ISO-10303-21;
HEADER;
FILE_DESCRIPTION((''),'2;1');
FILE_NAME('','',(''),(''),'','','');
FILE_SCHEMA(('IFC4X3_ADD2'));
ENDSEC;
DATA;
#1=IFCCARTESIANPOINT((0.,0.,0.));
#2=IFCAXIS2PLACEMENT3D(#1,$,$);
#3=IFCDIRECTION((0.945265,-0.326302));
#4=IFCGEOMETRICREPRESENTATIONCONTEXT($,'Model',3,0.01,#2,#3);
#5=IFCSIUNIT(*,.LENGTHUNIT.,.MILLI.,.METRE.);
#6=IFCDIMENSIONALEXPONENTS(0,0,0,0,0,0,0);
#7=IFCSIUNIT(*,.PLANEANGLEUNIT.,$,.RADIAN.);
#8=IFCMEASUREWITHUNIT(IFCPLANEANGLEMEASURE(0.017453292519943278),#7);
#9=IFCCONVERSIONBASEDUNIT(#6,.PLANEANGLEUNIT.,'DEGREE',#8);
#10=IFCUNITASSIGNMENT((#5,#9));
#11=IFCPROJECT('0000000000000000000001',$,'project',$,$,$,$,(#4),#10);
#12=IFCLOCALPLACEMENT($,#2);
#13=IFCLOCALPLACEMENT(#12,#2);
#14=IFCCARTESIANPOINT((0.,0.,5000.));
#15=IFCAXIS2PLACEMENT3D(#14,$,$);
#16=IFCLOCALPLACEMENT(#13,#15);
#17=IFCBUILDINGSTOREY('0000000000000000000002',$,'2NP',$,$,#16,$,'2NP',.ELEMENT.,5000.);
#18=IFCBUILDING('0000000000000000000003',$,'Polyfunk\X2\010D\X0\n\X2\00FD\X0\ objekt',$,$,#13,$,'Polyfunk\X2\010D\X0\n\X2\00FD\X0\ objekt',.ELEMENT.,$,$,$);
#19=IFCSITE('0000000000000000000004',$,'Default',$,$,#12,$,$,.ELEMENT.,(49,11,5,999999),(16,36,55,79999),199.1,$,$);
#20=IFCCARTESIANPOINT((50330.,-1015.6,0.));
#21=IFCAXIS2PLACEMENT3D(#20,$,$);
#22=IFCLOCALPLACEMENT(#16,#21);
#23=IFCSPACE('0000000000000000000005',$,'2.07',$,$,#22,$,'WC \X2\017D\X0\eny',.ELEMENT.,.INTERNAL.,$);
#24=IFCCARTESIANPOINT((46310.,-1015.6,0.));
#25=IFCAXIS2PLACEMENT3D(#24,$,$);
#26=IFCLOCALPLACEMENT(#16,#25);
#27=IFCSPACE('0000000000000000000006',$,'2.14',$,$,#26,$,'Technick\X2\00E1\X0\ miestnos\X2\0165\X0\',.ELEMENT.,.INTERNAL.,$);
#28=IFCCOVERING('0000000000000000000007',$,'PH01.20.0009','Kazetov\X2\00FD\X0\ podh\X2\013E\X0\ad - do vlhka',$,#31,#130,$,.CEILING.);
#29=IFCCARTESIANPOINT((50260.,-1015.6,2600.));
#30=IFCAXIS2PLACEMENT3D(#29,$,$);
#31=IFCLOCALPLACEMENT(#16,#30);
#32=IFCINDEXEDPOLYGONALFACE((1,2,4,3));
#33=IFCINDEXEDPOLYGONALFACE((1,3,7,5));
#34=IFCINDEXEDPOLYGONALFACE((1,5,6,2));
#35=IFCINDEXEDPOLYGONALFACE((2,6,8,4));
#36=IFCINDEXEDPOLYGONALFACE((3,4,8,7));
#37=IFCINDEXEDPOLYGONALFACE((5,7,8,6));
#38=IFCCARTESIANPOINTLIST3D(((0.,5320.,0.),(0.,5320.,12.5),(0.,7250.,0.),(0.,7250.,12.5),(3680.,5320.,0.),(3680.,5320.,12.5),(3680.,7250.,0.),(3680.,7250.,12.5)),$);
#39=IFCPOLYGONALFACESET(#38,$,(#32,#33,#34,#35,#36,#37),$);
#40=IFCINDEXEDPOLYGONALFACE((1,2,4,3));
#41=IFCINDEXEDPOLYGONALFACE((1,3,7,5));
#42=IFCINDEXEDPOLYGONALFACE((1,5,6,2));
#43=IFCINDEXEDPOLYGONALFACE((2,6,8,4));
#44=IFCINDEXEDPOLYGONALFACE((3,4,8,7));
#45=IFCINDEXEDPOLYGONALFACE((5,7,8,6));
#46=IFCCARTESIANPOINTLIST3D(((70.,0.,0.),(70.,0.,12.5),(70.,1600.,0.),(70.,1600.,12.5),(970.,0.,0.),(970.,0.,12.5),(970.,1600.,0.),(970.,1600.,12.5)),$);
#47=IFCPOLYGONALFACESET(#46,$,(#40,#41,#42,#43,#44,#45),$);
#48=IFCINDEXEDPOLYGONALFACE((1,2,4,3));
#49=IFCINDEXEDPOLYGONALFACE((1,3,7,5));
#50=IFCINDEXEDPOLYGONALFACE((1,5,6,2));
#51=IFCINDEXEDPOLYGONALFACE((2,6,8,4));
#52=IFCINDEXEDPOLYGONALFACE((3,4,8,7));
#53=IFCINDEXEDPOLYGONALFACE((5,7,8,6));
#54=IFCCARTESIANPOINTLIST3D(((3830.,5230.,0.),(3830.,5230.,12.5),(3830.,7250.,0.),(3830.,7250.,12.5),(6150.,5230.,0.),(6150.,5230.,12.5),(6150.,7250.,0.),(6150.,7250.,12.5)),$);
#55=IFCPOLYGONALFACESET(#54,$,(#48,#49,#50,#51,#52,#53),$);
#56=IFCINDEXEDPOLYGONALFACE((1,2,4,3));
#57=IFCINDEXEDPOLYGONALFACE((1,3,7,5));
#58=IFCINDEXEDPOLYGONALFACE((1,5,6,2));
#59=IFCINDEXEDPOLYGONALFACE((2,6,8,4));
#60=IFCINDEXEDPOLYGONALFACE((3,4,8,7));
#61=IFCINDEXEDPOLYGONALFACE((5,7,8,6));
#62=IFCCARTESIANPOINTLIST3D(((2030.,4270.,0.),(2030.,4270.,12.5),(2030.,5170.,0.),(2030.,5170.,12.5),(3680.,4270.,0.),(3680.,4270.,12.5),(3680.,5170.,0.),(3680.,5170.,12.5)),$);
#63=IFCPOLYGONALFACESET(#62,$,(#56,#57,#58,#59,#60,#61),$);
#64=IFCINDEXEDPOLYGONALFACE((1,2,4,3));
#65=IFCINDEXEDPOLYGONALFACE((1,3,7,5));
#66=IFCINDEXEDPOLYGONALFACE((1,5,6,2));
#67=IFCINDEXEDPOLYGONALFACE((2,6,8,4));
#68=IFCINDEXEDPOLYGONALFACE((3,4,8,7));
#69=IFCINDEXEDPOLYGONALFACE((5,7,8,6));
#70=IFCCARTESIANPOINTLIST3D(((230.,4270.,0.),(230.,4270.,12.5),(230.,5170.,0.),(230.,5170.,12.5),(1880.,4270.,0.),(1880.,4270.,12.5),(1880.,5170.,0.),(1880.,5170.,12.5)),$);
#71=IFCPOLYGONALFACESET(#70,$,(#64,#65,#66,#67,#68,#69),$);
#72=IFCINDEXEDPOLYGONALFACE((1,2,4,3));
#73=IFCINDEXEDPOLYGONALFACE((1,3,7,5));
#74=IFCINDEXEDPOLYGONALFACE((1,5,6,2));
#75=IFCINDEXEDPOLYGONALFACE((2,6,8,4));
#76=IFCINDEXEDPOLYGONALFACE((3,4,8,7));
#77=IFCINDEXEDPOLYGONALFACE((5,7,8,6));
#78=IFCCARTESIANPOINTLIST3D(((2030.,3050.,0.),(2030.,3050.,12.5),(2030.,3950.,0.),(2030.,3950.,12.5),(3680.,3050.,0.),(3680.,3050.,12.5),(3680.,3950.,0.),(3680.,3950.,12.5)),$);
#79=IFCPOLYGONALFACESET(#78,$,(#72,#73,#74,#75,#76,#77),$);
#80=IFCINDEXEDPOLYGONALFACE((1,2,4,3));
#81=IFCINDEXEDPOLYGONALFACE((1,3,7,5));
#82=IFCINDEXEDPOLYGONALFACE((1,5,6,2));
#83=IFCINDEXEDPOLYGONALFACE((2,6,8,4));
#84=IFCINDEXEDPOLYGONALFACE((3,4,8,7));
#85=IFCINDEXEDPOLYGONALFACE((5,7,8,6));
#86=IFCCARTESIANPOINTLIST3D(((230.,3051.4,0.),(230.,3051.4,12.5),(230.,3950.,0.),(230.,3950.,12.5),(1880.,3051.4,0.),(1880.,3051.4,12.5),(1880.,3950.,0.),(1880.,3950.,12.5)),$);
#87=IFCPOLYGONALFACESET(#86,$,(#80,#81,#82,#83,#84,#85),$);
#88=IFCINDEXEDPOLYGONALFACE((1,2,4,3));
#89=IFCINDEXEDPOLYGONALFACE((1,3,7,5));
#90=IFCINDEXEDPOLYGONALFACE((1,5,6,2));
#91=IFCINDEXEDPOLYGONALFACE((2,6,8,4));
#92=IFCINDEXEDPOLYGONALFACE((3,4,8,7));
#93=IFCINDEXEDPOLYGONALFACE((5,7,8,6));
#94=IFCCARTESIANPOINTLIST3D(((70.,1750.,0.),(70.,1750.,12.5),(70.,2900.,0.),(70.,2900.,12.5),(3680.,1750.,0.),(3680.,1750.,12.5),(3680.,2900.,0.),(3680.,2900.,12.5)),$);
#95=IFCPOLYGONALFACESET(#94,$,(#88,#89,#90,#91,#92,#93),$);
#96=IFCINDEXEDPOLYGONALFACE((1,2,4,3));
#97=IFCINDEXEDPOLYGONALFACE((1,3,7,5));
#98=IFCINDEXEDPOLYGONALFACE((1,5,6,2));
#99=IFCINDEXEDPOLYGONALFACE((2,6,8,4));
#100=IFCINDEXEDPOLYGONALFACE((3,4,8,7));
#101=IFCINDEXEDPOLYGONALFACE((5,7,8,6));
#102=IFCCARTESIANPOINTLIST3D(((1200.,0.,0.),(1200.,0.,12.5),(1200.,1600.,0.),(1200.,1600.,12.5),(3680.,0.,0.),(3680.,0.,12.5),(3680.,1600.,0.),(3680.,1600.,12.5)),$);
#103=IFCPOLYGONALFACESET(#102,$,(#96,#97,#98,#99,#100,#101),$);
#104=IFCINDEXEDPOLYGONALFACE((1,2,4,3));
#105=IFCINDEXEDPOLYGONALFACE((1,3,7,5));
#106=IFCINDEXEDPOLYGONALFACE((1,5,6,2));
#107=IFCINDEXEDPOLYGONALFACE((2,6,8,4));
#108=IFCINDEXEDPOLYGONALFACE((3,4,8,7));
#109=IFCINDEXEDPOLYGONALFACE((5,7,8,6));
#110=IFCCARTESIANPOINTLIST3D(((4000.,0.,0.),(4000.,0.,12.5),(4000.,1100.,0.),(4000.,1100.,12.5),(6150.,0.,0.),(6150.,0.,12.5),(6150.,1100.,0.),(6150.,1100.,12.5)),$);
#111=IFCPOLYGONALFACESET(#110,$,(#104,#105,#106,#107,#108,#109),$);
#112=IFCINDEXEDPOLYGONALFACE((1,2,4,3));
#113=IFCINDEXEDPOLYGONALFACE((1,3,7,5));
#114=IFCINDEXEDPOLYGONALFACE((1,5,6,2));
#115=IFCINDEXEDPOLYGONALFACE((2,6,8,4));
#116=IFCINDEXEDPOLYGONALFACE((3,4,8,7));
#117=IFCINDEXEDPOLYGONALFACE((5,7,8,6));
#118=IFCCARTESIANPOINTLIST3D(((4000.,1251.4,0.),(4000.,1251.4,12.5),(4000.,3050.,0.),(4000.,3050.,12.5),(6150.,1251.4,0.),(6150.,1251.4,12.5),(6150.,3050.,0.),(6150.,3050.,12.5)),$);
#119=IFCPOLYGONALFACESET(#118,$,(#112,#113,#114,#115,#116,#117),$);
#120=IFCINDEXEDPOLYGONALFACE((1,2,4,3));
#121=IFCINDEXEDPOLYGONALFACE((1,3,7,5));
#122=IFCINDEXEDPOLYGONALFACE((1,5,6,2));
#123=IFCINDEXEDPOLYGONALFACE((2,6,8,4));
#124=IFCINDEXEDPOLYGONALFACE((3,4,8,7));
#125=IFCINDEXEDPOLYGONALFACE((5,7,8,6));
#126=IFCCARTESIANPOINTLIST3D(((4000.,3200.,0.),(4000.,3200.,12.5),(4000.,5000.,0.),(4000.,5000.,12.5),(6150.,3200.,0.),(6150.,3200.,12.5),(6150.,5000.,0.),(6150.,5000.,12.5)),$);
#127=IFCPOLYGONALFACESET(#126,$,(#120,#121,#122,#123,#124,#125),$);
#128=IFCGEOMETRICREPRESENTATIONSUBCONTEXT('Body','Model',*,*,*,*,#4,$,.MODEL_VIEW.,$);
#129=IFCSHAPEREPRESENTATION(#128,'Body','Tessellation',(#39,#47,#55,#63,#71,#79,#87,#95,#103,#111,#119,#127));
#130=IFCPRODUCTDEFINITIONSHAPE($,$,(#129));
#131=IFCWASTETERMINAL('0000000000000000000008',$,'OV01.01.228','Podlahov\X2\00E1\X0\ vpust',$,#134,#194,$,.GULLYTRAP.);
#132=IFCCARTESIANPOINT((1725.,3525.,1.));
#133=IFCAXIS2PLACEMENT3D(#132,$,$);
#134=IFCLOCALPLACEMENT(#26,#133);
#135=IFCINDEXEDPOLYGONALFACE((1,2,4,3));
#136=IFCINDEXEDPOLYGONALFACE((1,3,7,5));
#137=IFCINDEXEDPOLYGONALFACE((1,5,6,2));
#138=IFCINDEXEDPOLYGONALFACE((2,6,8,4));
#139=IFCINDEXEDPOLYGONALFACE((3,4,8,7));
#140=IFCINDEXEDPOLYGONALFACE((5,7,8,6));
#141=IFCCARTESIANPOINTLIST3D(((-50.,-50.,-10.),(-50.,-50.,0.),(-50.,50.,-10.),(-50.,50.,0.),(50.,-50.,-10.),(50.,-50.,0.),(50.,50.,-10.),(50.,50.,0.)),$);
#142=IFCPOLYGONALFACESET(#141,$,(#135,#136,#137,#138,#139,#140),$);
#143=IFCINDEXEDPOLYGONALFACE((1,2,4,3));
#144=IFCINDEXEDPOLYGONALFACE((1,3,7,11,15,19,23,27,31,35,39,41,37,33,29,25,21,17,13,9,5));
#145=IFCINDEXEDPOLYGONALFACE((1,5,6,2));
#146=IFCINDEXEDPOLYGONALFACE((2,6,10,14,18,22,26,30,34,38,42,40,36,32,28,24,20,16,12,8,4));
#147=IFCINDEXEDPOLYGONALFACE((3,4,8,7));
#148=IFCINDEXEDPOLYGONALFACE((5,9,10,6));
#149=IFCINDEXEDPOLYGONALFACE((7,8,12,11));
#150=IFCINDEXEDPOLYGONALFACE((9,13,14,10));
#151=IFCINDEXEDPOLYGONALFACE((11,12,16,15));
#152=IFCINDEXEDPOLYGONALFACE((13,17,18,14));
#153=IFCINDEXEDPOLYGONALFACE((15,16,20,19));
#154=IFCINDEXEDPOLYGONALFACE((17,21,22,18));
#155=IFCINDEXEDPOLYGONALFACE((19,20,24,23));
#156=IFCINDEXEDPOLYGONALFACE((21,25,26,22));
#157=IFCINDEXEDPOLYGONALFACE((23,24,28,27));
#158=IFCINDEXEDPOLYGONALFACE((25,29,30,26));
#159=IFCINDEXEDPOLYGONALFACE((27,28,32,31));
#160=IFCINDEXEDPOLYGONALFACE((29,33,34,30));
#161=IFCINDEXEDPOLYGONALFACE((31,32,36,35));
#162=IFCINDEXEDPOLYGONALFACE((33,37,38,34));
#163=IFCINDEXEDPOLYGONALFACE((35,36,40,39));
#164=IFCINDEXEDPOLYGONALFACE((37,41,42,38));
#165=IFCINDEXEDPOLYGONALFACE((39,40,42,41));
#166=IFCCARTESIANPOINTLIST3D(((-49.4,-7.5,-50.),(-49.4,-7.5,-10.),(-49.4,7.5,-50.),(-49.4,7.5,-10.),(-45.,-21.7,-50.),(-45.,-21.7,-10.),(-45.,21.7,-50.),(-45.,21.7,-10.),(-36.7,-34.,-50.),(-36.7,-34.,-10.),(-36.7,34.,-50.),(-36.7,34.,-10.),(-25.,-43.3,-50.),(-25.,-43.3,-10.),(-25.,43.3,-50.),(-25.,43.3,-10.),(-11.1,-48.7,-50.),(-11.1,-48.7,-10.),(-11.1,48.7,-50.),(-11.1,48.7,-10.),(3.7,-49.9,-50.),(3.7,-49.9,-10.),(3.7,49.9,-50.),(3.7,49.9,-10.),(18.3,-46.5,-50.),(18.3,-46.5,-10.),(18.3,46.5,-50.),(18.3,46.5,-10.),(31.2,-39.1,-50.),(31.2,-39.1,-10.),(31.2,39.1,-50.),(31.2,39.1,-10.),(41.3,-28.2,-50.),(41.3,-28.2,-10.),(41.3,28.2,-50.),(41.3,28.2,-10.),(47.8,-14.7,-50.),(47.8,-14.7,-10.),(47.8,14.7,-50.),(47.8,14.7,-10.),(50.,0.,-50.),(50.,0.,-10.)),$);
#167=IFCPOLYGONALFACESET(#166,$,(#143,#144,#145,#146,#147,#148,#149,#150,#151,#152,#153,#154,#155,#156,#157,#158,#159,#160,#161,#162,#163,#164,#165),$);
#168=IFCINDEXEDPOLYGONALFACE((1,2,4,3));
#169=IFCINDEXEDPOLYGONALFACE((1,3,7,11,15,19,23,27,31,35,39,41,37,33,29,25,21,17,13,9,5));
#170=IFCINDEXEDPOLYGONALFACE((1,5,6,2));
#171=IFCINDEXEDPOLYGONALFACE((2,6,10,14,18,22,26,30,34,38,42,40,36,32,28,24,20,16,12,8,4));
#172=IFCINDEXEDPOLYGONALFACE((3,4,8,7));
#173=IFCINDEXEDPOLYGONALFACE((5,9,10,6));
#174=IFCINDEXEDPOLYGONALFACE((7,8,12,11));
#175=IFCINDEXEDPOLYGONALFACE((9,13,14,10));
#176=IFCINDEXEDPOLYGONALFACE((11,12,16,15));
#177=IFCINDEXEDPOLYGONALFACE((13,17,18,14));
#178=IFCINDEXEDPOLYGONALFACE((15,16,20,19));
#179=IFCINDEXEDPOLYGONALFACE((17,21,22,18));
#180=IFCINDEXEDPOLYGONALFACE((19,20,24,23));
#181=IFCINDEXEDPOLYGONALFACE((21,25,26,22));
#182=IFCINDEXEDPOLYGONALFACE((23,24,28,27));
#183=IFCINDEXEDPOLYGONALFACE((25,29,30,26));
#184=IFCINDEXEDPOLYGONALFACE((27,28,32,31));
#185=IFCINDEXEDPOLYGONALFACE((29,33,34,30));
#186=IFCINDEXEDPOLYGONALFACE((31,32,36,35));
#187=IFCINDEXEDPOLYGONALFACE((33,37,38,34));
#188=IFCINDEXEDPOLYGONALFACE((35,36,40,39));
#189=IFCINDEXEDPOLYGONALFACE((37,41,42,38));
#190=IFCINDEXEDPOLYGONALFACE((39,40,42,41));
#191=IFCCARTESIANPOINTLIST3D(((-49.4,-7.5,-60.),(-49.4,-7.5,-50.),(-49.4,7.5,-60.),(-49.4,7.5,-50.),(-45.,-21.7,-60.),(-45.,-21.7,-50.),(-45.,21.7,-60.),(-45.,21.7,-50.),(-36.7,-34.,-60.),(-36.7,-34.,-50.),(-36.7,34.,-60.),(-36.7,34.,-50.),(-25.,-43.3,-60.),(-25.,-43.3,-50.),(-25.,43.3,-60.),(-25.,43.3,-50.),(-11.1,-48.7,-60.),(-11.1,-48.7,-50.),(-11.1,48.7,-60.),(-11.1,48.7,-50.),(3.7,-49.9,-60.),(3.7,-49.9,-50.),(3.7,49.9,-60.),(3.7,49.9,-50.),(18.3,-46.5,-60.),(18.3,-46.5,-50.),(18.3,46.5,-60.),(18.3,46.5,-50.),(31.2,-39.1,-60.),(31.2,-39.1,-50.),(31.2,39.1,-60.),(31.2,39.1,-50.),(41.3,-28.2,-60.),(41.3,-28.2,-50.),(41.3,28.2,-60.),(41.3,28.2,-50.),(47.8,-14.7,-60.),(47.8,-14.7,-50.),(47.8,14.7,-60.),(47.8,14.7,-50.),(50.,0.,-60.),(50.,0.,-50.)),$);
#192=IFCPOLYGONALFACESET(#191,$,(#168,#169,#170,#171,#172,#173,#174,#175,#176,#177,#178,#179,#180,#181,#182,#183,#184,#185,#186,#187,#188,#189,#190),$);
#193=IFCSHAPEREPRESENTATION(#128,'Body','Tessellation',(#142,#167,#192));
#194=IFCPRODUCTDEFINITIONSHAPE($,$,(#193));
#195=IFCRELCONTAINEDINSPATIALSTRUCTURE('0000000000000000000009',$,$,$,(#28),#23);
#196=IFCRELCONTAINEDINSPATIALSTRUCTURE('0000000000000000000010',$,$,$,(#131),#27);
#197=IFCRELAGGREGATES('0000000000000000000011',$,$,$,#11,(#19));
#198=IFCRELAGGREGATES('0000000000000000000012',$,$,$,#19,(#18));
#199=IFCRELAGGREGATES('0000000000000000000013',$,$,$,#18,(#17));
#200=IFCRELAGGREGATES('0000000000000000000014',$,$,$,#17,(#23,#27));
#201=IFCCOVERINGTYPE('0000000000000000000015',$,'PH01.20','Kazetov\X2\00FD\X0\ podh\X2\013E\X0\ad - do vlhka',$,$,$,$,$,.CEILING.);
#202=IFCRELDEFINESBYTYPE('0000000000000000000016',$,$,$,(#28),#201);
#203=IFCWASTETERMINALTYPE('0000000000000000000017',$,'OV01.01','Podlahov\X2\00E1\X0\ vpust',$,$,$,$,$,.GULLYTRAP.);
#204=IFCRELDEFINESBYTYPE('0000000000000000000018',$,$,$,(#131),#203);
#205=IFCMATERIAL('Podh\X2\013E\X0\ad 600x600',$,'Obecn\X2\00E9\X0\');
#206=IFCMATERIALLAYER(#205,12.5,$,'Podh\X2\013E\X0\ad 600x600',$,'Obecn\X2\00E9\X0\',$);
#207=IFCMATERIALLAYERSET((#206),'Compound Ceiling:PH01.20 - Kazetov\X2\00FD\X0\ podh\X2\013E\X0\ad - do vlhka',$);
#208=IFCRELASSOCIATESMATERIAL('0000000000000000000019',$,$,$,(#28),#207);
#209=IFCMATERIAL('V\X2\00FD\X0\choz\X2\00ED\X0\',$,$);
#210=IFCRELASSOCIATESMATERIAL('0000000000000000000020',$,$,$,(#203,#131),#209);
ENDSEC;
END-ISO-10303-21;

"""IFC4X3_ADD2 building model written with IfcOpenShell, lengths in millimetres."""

from ifc_helpers import new_model, entity, si_unit, converted_unit, direction, frame, frame_2d, origin, origin_2d_with_axis, place, context, subcontext, project, spatial, rectangle, circle, extrude, source, transform, mapped, material, layer, layer_set, layer_usage, type_object, type_shapes, element, save


model = new_model("IFC4X3_ADD2")

# Units and contexts
model_context = context("Model", 3, precision=0.01, world=origin(), true_north=direction((0.945265, -0.326302)))
body_context = subcontext(model_context, "Body", "Model", "MODEL_VIEW")
ifc_project = project(units=[si_unit("LENGTHUNIT", "METRE", prefix="MILLI"), converted_unit("PLANEANGLEUNIT", "DEGREE", entity("IfcPlaneAngleMeasure", 0.017453292519943278), si_unit("PLANEANGLEUNIT", "RADIAN"), dimensions=[0, 0, 0, 0, 0, 0, 0])], contexts=[model_context])

# Site, building, storey
site_placement = place(None, origin())
site = spatial("IfcSite", under=ifc_project, at=site_placement, Name="Default", CompositionType="ELEMENT", RefLatitude=(49, 11, 5, 999999), RefLongitude=(16, 36, 55, 79999), RefElevation=199.1)
building_placement = place(site_placement, origin())
building = spatial("IfcBuilding", under=site, at=building_placement, Name="Polyfunkčný objekt", LongName="Polyfunkčný objekt", CompositionType="ELEMENT")
storey_placement = place(building_placement, frame((0.0, 0.0, 5000.0)))
storey = spatial("IfcBuildingStorey", under=building, at=storey_placement, Name="2NP", LongName="2NP", CompositionType="ELEMENT", Elevation=5000.0)

# Shared definitions
space_1_placement = place(storey_placement, frame((50330.0, -1015.6, 0.0)))
space_1 = spatial("IfcSpace", under=storey, at=space_1_placement, Name="2.07", LongName="WC Ženy", CompositionType="ELEMENT", PredefinedType="INTERNAL")

# Covering
ifc_material_1 = material(Name="Podhľad 600x600", Category="Obecné")
ifc_layer_1 = layer(ifc_material_1, 12.5, Name="Podhľad 600x600", Category="Obecné")
ifc_layer_set_1 = layer_set([ifc_layer_1], Name="Compound Ceiling:PH01.20 - Kazetový podhľad - do vlhka")
ifc_layer_usage_1 = layer_usage(ifc_layer_set_1, "AXIS3", "NEGATIVE", 0.0)
covering_type = type_object("IfcCoveringType", Name="PH01.20", Description="Kazetový podhľad - do vlhka", PredefinedType="CEILING")
covering_placement = place(storey_placement, frame((50260.0, -1015.6, 2600.0)))
element("IfcCovering", 1, at=covering_placement, inside=space_1, type_object=covering_type, material=ifc_layer_usage_1, Name="PH01.20.0009", Description="Kazetový podhľad - do vlhka", PredefinedType="CEILING", context=body_context, shape_type="SweptSolid", body=[
    extrude(rectangle(XDim=1930.0, YDim=3680.0, at=frame_2d((0.0, 0.0), x_axis=(1.0, 0.0))), frame((1840.0, 6285.0, 0.0), z_axis=(0.0, 0.0, 1.0), x_axis=(0.0, -1.0, 0.0)), (0.0, 0.0, 1.0), 12.5),
    extrude(rectangle(XDim=1600.0, YDim=900.0, at=origin_2d_with_axis()), frame((520.0, 800.0, 0.0), z_axis=(0.0, 0.0, 1.0), x_axis=(0.0, 1.0, 0.0)), (0.0, 0.0, 1.0), 12.5),
    extrude(rectangle(XDim=2320.0, YDim=2020.0, at=frame_2d((0.0, 0.0), x_axis=(1.0, 0.0))), frame((4990.0, 6240.0, 0.0), z_axis=(0.0, 0.0, 1.0), x_axis=(-1.0, 0.0, 0.0)), (0.0, 0.0, 1.0), 12.5),
    extrude(rectangle(XDim=900.0, YDim=1650.0, at=frame_2d((0.0, 0.0), x_axis=(1.0, 0.0))), frame((2855.0, 4720.0, 0.0), z_axis=(0.0, 0.0, 1.0), x_axis=(0.0, 1.0, 0.0)), (0.0, 0.0, 1.0), 12.5),
    extrude(rectangle(XDim=1650.0, YDim=900.0, at=frame_2d((0.0, 0.0), x_axis=(1.0, 0.0))), frame((1055.0, 4720.0, 0.0), z_axis=(0.0, 0.0, 1.0), x_axis=(-1.0, 0.0, 0.0)), (0.0, 0.0, 1.0), 12.5),
    extrude(rectangle(XDim=900.0, YDim=1650.0, at=frame_2d((0.0, 0.0), x_axis=(1.0, 0.0))), frame((2855.0, 3500.0, 0.0), z_axis=(0.0, 0.0, 1.0), x_axis=(0.0, -1.0, 0.0)), (0.0, 0.0, 1.0), 12.5),
    extrude(rectangle(XDim=1650.0, YDim=898.6, at=frame_2d((0.0, 0.0), x_axis=(1.0, 0.0))), frame((1055.0, 3500.7, 0.0), z_axis=(0.0, 0.0, 1.0), x_axis=(-1.0, 0.0, 0.0)), (0.0, 0.0, 1.0), 12.5),
    extrude(rectangle(XDim=3610.0, YDim=1150.0, at=frame_2d((0.0, 0.0), x_axis=(1.0, 0.0))), frame((1875.0, 2325.0, 0.0), z_axis=(0.0, 0.0, 1.0), x_axis=(-1.0, 0.0, 0.0)), (0.0, 0.0, 1.0), 12.5),
    extrude(rectangle(XDim=2480.0, YDim=1600.0, at=origin_2d_with_axis()), frame((2440.0, 800.0, 0.0), z_axis=(0.0, 0.0, 1.0), x_axis=(-1.0, 0.0, 0.0)), (0.0, 0.0, 1.0), 12.5),
    extrude(rectangle(XDim=1100.0, YDim=2150.0, at=frame_2d((0.0, 0.0), x_axis=(1.0, 0.0))), frame((5075.0, 550.0, 0.0), z_axis=(0.0, 0.0, 1.0), x_axis=(0.0, 1.0, 0.0)), (0.0, 0.0, 1.0), 12.5),
    extrude(rectangle(XDim=1798.6, YDim=2150.0, at=origin_2d_with_axis()), frame((5075.0, 2150.7, 0.0), z_axis=(0.0, 0.0, 1.0), x_axis=(0.0, 1.0, 0.0)), (0.0, 0.0, 1.0), 12.5),
    extrude(rectangle(XDim=1800.0, YDim=2150.0, at=frame_2d((0.0, 0.0), x_axis=(1.0, 0.0))), frame((5075.0, 4100.0, 0.0), z_axis=(0.0, 0.0, 1.0), x_axis=(0.0, 1.0, 0.0)), (0.0, 0.0, 1.0), 12.5),
])

# Shared definitions
space_2_placement = place(storey_placement, frame((46310.0, -1015.6, 0.0)))
space_2 = spatial("IfcSpace", under=storey, at=space_2_placement, Name="2.14", LongName="Technická miestnosť", CompositionType="ELEMENT", PredefinedType="INTERNAL")

# Waste terminal
ifc_material_2 = material(Name="Výchozí")
waste_terminal_type = type_object("IfcWasteTerminalType", Name="OV01.01", Description="Podlahová vpust", PredefinedType="GULLYTRAP", material=ifc_material_2)
shared_shape_1 = source(origin(), body_context, "Body", "SweptSolid", [
    extrude(rectangle(XDim=100.0, YDim=100.0, at=frame_2d((0.0, 0.0), x_axis=(1.0, 0.0))), frame((0.0, 0.0, -10.0), z_axis=(0.0, 0.0, 1.0), x_axis=(-1.0, 0.0, 0.0)), (0.0, 0.0, 1.0), 10.0),
    extrude(circle(Radius=50.0, at=frame_2d((0.0, 0.0), x_axis=(1.0, 0.0))), frame((0.0, 0.0, -50.0)), (0.0, 0.0, 1.0), 40.0),
    extrude(circle(Radius=50.0, at=frame_2d((0.0, 0.0), x_axis=(1.0, 0.0))), frame((0.0, 0.0, -60.0)), (0.0, 0.0, 1.0), 10.0),
])
type_shapes(waste_terminal_type, [shared_shape_1])
waste_terminal_placement = place(space_2_placement, frame((1725.0, 3525.0, 1.0)))
element("IfcWasteTerminal", 2, at=waste_terminal_placement, inside=space_2, type_object=waste_terminal_type, material=ifc_material_2, Name="OV01.01.228", Description="Podlahová vpust", PredefinedType="GULLYTRAP", context=body_context, shape_type="MappedRepresentation", body=[
    mapped(shared_shape_1, transform((0.0, 0.0, 0.0), scale=1.0)),
])

save(model, "model.ifc")
